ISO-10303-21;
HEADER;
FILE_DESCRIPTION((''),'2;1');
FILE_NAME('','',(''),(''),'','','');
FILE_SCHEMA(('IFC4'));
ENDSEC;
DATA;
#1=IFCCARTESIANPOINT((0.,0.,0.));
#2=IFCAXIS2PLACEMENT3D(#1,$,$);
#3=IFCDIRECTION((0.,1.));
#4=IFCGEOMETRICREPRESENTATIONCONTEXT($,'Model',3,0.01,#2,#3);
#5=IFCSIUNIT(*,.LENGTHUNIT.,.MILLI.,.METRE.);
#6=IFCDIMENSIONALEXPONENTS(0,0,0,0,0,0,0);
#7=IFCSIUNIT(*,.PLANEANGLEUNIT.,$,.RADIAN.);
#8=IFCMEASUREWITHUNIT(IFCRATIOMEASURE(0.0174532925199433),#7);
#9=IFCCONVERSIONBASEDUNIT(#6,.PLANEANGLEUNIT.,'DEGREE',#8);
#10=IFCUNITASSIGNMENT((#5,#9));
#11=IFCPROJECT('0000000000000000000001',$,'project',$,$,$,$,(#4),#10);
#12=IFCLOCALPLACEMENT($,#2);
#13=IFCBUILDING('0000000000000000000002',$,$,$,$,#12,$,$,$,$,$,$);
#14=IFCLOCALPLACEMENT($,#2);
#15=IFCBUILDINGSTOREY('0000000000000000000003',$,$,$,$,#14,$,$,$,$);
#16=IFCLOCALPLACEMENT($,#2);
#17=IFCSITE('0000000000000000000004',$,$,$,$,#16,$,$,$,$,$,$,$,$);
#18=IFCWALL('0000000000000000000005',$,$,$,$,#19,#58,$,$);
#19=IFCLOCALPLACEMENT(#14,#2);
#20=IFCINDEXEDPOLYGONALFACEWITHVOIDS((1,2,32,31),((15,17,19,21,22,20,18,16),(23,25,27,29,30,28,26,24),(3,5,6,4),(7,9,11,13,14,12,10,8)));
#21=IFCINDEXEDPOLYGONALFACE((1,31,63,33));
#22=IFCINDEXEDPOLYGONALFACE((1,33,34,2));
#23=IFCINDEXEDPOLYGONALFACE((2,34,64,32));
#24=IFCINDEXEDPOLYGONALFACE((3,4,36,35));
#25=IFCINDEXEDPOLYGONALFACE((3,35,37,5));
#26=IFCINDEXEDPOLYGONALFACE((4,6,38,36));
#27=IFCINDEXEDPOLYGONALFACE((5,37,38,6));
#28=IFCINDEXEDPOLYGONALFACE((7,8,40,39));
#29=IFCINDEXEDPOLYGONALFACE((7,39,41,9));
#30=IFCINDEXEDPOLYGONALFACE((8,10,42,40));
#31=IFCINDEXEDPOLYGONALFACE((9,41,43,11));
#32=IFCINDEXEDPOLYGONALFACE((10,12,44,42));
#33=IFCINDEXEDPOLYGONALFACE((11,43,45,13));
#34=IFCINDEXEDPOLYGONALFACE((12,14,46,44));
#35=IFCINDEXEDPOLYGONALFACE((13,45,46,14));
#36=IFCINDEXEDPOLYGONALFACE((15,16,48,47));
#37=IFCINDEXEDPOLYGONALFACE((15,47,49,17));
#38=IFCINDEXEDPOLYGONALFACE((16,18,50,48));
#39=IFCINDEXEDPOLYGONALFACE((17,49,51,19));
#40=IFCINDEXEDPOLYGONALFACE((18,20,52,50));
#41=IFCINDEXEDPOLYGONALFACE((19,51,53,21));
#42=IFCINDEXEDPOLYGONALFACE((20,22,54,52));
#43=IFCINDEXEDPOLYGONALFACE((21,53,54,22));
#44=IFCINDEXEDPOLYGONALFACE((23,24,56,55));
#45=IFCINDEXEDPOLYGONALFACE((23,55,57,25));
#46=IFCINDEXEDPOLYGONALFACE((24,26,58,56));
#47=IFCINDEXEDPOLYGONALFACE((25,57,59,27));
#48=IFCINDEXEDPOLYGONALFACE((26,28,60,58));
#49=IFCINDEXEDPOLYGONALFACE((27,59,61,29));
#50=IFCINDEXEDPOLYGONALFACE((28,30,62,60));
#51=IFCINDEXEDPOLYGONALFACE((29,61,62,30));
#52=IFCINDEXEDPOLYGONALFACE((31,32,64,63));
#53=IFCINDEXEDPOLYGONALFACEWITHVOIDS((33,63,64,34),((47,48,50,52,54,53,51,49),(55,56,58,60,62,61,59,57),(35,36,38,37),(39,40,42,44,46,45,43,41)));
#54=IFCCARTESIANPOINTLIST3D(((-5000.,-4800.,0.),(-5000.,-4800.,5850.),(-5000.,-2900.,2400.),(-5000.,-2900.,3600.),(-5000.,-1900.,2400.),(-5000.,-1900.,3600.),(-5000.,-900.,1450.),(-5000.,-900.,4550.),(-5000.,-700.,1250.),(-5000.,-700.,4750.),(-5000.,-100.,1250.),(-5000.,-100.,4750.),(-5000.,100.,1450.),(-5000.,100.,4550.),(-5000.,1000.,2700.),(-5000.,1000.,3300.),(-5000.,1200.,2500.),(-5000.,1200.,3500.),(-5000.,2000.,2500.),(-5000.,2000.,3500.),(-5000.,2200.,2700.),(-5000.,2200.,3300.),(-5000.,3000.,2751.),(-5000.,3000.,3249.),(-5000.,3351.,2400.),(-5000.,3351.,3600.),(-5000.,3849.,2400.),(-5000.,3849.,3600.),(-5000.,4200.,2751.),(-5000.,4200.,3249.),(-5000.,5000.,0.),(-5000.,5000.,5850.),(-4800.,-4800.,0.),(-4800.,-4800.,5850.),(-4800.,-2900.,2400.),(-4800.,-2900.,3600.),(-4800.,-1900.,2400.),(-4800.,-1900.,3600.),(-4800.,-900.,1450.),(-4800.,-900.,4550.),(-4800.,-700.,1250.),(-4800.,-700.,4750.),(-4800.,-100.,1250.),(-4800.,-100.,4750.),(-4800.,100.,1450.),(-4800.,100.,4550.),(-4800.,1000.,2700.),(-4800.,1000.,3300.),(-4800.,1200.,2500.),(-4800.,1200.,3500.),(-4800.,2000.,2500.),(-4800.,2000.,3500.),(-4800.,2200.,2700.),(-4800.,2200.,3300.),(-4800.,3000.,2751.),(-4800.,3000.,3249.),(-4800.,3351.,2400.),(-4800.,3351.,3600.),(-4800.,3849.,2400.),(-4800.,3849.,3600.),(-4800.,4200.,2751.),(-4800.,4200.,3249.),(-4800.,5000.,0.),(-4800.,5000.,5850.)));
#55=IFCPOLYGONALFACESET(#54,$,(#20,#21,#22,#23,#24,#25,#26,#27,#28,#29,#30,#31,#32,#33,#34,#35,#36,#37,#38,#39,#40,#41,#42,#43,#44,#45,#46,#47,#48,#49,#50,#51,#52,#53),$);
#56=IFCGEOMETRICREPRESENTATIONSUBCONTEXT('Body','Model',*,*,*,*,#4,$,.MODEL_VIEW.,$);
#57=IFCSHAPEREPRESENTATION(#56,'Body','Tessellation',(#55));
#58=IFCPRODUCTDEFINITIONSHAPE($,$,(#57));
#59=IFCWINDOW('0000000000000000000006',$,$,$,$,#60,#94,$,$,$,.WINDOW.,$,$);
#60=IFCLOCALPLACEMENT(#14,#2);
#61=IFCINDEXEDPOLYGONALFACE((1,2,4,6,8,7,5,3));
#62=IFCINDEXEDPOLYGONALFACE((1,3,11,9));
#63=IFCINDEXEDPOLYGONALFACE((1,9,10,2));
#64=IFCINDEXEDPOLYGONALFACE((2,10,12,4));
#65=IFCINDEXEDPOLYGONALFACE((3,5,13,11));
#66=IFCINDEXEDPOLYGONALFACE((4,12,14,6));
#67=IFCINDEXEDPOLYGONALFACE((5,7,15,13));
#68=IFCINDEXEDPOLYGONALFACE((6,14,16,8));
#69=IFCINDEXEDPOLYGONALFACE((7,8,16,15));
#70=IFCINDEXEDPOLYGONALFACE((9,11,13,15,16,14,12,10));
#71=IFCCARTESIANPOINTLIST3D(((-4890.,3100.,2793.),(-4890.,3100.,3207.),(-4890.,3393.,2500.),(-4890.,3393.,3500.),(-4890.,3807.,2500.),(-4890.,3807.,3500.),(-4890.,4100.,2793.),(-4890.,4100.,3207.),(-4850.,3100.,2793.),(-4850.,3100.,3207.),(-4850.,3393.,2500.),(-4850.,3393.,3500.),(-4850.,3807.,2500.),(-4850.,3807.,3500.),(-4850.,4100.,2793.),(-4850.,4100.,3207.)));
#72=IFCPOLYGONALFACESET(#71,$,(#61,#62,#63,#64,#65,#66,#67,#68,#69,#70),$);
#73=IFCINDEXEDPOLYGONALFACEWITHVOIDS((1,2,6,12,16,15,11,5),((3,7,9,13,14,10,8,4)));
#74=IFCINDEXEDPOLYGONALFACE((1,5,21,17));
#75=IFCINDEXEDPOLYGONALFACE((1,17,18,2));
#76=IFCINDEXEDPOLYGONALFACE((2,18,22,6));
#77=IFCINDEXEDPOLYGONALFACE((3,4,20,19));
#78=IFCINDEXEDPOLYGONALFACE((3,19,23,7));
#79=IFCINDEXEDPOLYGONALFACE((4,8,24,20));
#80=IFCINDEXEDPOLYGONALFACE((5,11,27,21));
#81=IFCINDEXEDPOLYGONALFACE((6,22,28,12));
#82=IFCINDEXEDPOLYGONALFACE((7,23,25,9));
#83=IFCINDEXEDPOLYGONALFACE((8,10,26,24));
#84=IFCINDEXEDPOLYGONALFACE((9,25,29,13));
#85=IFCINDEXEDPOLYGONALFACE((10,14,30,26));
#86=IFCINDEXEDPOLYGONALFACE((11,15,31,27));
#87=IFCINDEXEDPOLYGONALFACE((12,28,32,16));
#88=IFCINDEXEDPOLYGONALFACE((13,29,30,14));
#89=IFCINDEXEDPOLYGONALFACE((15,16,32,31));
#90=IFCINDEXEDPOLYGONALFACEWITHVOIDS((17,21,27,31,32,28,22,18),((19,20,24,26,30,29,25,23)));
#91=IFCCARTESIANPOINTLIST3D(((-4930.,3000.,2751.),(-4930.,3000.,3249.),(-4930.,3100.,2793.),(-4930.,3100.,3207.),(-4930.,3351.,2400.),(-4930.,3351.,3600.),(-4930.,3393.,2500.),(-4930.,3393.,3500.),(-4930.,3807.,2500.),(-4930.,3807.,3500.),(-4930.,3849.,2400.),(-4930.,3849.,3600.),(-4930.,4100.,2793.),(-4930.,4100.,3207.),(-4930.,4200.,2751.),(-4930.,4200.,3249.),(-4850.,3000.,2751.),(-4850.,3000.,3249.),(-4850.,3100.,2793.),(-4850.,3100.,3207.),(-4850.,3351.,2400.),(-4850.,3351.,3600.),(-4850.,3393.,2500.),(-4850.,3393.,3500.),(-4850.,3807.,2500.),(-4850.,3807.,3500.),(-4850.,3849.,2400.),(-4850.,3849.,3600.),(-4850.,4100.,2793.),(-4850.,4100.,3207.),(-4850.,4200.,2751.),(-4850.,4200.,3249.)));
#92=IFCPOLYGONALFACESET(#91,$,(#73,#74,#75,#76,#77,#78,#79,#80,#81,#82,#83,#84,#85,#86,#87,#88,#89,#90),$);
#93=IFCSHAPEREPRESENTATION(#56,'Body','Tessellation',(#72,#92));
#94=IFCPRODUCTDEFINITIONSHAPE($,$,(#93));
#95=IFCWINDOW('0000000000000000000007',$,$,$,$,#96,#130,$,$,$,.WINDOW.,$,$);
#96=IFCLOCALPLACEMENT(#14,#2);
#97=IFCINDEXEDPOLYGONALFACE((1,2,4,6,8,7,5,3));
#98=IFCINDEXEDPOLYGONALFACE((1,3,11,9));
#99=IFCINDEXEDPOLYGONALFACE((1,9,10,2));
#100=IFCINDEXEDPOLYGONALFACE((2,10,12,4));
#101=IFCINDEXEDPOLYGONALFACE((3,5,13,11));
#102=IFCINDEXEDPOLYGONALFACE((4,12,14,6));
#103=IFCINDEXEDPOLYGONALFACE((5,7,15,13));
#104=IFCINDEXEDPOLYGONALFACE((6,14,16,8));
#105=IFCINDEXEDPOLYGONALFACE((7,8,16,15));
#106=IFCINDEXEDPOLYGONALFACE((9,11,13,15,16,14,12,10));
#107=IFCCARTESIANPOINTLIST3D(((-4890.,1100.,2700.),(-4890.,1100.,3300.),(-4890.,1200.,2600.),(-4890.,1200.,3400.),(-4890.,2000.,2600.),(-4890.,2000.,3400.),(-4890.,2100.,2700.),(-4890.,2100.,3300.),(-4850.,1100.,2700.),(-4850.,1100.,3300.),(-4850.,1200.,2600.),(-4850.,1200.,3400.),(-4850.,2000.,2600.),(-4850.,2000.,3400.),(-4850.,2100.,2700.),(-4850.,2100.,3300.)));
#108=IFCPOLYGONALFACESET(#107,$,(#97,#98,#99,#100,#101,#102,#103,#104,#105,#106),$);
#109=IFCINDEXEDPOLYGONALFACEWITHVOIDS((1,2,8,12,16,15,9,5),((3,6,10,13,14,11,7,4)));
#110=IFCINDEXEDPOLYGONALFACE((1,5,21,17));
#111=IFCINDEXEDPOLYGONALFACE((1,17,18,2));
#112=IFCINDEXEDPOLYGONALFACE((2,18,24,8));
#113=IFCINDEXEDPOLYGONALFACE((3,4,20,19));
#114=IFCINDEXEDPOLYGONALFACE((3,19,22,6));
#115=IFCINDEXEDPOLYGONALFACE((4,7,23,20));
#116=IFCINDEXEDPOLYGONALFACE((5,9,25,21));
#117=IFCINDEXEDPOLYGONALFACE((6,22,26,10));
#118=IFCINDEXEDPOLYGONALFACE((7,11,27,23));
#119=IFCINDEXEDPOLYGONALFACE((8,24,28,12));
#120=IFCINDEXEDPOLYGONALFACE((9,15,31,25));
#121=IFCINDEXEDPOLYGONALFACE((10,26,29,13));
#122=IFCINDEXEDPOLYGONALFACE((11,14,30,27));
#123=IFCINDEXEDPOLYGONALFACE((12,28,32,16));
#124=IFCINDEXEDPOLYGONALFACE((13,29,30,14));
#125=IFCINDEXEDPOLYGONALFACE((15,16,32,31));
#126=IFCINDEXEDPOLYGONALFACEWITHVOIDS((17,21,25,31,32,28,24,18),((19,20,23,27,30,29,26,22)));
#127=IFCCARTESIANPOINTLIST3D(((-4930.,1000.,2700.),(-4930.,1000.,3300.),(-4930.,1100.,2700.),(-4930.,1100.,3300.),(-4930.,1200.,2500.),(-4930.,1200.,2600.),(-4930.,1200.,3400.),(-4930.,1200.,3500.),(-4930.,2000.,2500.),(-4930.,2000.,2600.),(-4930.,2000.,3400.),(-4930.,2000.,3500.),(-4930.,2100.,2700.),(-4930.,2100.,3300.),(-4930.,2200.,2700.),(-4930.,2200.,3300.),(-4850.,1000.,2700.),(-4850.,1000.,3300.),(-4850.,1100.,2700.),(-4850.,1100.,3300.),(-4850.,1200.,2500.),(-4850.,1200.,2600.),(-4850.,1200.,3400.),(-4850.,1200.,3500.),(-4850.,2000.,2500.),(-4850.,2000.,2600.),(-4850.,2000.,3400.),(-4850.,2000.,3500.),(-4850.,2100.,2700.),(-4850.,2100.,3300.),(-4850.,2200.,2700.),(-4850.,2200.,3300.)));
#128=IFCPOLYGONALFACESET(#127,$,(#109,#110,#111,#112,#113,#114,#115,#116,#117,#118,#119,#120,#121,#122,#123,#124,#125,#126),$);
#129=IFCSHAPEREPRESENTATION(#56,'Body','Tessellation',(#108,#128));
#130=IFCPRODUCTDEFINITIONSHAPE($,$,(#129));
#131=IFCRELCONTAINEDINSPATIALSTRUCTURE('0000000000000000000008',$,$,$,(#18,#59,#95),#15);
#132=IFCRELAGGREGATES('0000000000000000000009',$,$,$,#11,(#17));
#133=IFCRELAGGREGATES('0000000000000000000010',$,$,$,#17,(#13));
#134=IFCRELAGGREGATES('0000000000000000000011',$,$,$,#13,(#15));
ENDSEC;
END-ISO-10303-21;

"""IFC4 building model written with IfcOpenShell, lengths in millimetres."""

from ifc_helpers import new_model, entity, si_unit, converted_unit, direction, frame, origin, origin_2d, place, context, subcontext, project, spatial, polyline, rectangle, outline, extrude, element, save


model = new_model("IFC4")

# Units and contexts
model_context = context("Model", 3, precision=0.01, world=origin(), true_north=direction((0.0, 1.0)))
body_context = subcontext(model_context, "Body", "Model", "MODEL_VIEW")
ifc_project = project(units=[si_unit("LENGTHUNIT", "METRE", prefix="MILLI"), converted_unit("PLANEANGLEUNIT", "DEGREE", entity("IfcRatioMeasure", 0.0174532925199433), si_unit("PLANEANGLEUNIT", "RADIAN"), dimensions=[0, 0, 0, 0, 0, 0, 0])], contexts=[model_context])

# Site, building, storey
site_placement = place(None, origin())
site = spatial("IfcSite", under=ifc_project, at=site_placement)
building_placement = place(None, origin())
building = spatial("IfcBuilding", under=site, at=building_placement)
storey_placement = place(None, origin())
storey = spatial("IfcBuildingStorey", under=building, at=storey_placement)

# Shared definitions
cartesian_point_1 = entity("IfcCartesianPoint", [-500.0, -207.0])
shared_polyline_1 = entity("IfcPolyline", [cartesian_point_1, entity("IfcCartesianPoint", [-500.0, 207.0]), entity("IfcCartesianPoint", [-207.0, 500.0]), entity("IfcCartesianPoint", [207.0, 500.0]), entity("IfcCartesianPoint", [500.0, 207.0]), entity("IfcCartesianPoint", [500.0, -207.0]), entity("IfcCartesianPoint", [207.0, -500.0]), entity("IfcCartesianPoint", [-207.0, -500.0]), cartesian_point_1])
cartesian_point_2 = entity("IfcCartesianPoint", [-500.0, -300.0])
shared_polyline_2 = entity("IfcPolyline", [cartesian_point_2, entity("IfcCartesianPoint", [-500.0, 300.0]), entity("IfcCartesianPoint", [-400.0, 400.0]), entity("IfcCartesianPoint", [400.0, 400.0]), entity("IfcCartesianPoint", [500.0, 300.0]), entity("IfcCartesianPoint", [500.0, -300.0]), entity("IfcCartesianPoint", [400.0, -400.0]), entity("IfcCartesianPoint", [-400.0, -400.0]), cartesian_point_2])

# Wall, openings
wall_1_placement = place(storey_placement, frame((-4900.0, 100.0, 0.0), z_axis=(0.0, 0.0, 1.0), x_axis=(0.0, -1.0, 0.0)))
wall_1 = element("IfcWall", 1, at=wall_1_placement, inside=storey, context=body_context, shape_type="SweptSolid", body=[
    extrude(rectangle(XDim=9800.0, YDim=200.0, at=origin_2d()), origin(), (0.0, 0.0, 1.0), 5850.0),
])
window_1_placement = place(wall_1_placement, frame((-3500.0, 50.0, 3000.0)))
opening_1_placement = place(window_1_placement, frame((0.0, 50.0, 0.0)))
element("IfcOpeningElement", 2, at=opening_1_placement, cuts=wall_1, context=body_context, shape_type="SweptSolid", body=[
    extrude(outline(polyline([(-600.0, -249.0), (-600.0, 249.0), (-249.0, 600.0), (249.0, 600.0), (600.0, 249.0), (600.0, -249.0), (249.0, -600.0), (-249.0, -600.0), (-600.0, -249.0)])), frame((0.0, 0.0, 0.0), z_axis=(0.0, -1.0, 0.0), x_axis=(1.0, 0.0, 0.0)), (0.0, 0.0, 1.0), 200.0),
])
window_2_placement = place(wall_1_placement, frame((-1500.0, 50.0, 3000.0)))
opening_2_placement = place(window_2_placement, frame((0.0, 50.0, 0.0)))
element("IfcOpeningElement", 3, at=opening_2_placement, cuts=wall_1, context=body_context, shape_type="SweptSolid", body=[
    extrude(outline(polyline([(-600.0, -300.0), (-600.0, 300.0), (-400.0, 500.0), (400.0, 500.0), (600.0, 300.0), (600.0, -300.0), (400.0, -500.0), (-400.0, -500.0), (-600.0, -300.0)])), frame((0.0, 0.0, 0.0), z_axis=(0.0, -1.0, 0.0), x_axis=(1.0, 0.0, 0.0)), (0.0, 0.0, 1.0), 200.0),
])
window_3_placement = place(wall_1_placement, frame((500.0, 50.0, 3000.0)))
opening_3_placement = place(window_3_placement, frame((0.0, 50.0, 0.0)))
element("IfcOpeningElement", 4, at=opening_3_placement, cuts=wall_1, context=body_context, shape_type="SweptSolid", body=[
    extrude(outline(polyline([(-500.0, -1550.0), (-500.0, 1550.0), (-300.0, 1750.0), (300.0, 1750.0), (500.0, 1550.0), (500.0, -1550.0), (300.0, -1750.0), (-300.0, -1750.0), (-500.0, -1550.0)])), frame((0.0, 0.0, 0.0), z_axis=(0.0, -1.0, 0.0), x_axis=(1.0, 0.0, 0.0)), (0.0, 0.0, 1.0), 200.0),
])
window_4_placement = place(wall_1_placement, frame((2500.0, 50.0, 3000.0)))
opening_4_placement = place(window_4_placement, frame((0.0, 50.0, 0.0)))
element("IfcOpeningElement", 5, at=opening_4_placement, cuts=wall_1, context=body_context, shape_type="SweptSolid", body=[
    extrude(outline(polyline([(-500.0, -600.0), (-500.0, 600.0), (-500.0, 600.0), (500.0, 600.0), (500.0, 600.0), (500.0, -600.0), (500.0, -600.0), (-500.0, -600.0), (-500.0, -600.0)])), frame((0.0, 0.0, 0.0), z_axis=(0.0, -1.0, 0.0), x_axis=(1.0, 0.0, 0.0)), (0.0, 0.0, 1.0), 200.0),
])

# Windows
cartesian_point_3 = entity("IfcCartesianPoint", [-600.0, -249.0])
element("IfcWindow", 6, at=window_1_placement, inside=storey, PredefinedType="WINDOW", context=body_context, shape_type="SweptSolid", body=[
    entity("IfcExtrudedAreaSolid", entity("IfcArbitraryClosedProfileDef", "AREA", None, shared_polyline_1), entity("IfcAxis2Placement3D", entity("IfcCartesianPoint", [0.0, 0.0, 0.0]), entity("IfcDirection", [0.0, -1.0, 0.0]), entity("IfcDirection", [1.0, 0.0, 0.0])), entity("IfcDirection", [0.0, 0.0, 1.0]), 40.0),
    entity("IfcExtrudedAreaSolid", entity("IfcArbitraryProfileDefWithVoids", "AREA", None, entity("IfcPolyline", [cartesian_point_3, entity("IfcCartesianPoint", [-600.0, 249.0]), entity("IfcCartesianPoint", [-249.0, 600.0]), entity("IfcCartesianPoint", [249.0, 600.0]), entity("IfcCartesianPoint", [600.0, 249.0]), entity("IfcCartesianPoint", [600.0, -249.0]), entity("IfcCartesianPoint", [249.0, -600.0]), entity("IfcCartesianPoint", [-249.0, -600.0]), cartesian_point_3]), [shared_polyline_1]), entity("IfcAxis2Placement3D", entity("IfcCartesianPoint", [0.0, 0.0, 0.0]), entity("IfcDirection", [0.0, -1.0, 0.0]), entity("IfcDirection", [1.0, 0.0, 0.0])), entity("IfcDirection", [0.0, 0.0, 1.0]), 80.0),
])
cartesian_point_4 = entity("IfcCartesianPoint", [-600.0, -300.0])
element("IfcWindow", 7, at=window_2_placement, inside=storey, PredefinedType="WINDOW", context=body_context, shape_type="SweptSolid", body=[
    entity("IfcExtrudedAreaSolid", entity("IfcArbitraryClosedProfileDef", "AREA", None, shared_polyline_2), entity("IfcAxis2Placement3D", entity("IfcCartesianPoint", [0.0, 0.0, 0.0]), entity("IfcDirection", [0.0, -1.0, 0.0]), entity("IfcDirection", [1.0, 0.0, 0.0])), entity("IfcDirection", [0.0, 0.0, 1.0]), 40.0),
    entity("IfcExtrudedAreaSolid", entity("IfcArbitraryProfileDefWithVoids", "AREA", None, entity("IfcPolyline", [cartesian_point_4, entity("IfcCartesianPoint", [-600.0, 300.0]), entity("IfcCartesianPoint", [-400.0, 500.0]), entity("IfcCartesianPoint", [400.0, 500.0]), entity("IfcCartesianPoint", [600.0, 300.0]), entity("IfcCartesianPoint", [600.0, -300.0]), entity("IfcCartesianPoint", [400.0, -500.0]), entity("IfcCartesianPoint", [-400.0, -500.0]), cartesian_point_4]), [shared_polyline_2]), entity("IfcAxis2Placement3D", entity("IfcCartesianPoint", [0.0, 0.0, 0.0]), entity("IfcDirection", [0.0, -1.0, 0.0]), entity("IfcDirection", [1.0, 0.0, 0.0])), entity("IfcDirection", [0.0, 0.0, 1.0]), 80.0),
])

save(model, "model.ifc")
